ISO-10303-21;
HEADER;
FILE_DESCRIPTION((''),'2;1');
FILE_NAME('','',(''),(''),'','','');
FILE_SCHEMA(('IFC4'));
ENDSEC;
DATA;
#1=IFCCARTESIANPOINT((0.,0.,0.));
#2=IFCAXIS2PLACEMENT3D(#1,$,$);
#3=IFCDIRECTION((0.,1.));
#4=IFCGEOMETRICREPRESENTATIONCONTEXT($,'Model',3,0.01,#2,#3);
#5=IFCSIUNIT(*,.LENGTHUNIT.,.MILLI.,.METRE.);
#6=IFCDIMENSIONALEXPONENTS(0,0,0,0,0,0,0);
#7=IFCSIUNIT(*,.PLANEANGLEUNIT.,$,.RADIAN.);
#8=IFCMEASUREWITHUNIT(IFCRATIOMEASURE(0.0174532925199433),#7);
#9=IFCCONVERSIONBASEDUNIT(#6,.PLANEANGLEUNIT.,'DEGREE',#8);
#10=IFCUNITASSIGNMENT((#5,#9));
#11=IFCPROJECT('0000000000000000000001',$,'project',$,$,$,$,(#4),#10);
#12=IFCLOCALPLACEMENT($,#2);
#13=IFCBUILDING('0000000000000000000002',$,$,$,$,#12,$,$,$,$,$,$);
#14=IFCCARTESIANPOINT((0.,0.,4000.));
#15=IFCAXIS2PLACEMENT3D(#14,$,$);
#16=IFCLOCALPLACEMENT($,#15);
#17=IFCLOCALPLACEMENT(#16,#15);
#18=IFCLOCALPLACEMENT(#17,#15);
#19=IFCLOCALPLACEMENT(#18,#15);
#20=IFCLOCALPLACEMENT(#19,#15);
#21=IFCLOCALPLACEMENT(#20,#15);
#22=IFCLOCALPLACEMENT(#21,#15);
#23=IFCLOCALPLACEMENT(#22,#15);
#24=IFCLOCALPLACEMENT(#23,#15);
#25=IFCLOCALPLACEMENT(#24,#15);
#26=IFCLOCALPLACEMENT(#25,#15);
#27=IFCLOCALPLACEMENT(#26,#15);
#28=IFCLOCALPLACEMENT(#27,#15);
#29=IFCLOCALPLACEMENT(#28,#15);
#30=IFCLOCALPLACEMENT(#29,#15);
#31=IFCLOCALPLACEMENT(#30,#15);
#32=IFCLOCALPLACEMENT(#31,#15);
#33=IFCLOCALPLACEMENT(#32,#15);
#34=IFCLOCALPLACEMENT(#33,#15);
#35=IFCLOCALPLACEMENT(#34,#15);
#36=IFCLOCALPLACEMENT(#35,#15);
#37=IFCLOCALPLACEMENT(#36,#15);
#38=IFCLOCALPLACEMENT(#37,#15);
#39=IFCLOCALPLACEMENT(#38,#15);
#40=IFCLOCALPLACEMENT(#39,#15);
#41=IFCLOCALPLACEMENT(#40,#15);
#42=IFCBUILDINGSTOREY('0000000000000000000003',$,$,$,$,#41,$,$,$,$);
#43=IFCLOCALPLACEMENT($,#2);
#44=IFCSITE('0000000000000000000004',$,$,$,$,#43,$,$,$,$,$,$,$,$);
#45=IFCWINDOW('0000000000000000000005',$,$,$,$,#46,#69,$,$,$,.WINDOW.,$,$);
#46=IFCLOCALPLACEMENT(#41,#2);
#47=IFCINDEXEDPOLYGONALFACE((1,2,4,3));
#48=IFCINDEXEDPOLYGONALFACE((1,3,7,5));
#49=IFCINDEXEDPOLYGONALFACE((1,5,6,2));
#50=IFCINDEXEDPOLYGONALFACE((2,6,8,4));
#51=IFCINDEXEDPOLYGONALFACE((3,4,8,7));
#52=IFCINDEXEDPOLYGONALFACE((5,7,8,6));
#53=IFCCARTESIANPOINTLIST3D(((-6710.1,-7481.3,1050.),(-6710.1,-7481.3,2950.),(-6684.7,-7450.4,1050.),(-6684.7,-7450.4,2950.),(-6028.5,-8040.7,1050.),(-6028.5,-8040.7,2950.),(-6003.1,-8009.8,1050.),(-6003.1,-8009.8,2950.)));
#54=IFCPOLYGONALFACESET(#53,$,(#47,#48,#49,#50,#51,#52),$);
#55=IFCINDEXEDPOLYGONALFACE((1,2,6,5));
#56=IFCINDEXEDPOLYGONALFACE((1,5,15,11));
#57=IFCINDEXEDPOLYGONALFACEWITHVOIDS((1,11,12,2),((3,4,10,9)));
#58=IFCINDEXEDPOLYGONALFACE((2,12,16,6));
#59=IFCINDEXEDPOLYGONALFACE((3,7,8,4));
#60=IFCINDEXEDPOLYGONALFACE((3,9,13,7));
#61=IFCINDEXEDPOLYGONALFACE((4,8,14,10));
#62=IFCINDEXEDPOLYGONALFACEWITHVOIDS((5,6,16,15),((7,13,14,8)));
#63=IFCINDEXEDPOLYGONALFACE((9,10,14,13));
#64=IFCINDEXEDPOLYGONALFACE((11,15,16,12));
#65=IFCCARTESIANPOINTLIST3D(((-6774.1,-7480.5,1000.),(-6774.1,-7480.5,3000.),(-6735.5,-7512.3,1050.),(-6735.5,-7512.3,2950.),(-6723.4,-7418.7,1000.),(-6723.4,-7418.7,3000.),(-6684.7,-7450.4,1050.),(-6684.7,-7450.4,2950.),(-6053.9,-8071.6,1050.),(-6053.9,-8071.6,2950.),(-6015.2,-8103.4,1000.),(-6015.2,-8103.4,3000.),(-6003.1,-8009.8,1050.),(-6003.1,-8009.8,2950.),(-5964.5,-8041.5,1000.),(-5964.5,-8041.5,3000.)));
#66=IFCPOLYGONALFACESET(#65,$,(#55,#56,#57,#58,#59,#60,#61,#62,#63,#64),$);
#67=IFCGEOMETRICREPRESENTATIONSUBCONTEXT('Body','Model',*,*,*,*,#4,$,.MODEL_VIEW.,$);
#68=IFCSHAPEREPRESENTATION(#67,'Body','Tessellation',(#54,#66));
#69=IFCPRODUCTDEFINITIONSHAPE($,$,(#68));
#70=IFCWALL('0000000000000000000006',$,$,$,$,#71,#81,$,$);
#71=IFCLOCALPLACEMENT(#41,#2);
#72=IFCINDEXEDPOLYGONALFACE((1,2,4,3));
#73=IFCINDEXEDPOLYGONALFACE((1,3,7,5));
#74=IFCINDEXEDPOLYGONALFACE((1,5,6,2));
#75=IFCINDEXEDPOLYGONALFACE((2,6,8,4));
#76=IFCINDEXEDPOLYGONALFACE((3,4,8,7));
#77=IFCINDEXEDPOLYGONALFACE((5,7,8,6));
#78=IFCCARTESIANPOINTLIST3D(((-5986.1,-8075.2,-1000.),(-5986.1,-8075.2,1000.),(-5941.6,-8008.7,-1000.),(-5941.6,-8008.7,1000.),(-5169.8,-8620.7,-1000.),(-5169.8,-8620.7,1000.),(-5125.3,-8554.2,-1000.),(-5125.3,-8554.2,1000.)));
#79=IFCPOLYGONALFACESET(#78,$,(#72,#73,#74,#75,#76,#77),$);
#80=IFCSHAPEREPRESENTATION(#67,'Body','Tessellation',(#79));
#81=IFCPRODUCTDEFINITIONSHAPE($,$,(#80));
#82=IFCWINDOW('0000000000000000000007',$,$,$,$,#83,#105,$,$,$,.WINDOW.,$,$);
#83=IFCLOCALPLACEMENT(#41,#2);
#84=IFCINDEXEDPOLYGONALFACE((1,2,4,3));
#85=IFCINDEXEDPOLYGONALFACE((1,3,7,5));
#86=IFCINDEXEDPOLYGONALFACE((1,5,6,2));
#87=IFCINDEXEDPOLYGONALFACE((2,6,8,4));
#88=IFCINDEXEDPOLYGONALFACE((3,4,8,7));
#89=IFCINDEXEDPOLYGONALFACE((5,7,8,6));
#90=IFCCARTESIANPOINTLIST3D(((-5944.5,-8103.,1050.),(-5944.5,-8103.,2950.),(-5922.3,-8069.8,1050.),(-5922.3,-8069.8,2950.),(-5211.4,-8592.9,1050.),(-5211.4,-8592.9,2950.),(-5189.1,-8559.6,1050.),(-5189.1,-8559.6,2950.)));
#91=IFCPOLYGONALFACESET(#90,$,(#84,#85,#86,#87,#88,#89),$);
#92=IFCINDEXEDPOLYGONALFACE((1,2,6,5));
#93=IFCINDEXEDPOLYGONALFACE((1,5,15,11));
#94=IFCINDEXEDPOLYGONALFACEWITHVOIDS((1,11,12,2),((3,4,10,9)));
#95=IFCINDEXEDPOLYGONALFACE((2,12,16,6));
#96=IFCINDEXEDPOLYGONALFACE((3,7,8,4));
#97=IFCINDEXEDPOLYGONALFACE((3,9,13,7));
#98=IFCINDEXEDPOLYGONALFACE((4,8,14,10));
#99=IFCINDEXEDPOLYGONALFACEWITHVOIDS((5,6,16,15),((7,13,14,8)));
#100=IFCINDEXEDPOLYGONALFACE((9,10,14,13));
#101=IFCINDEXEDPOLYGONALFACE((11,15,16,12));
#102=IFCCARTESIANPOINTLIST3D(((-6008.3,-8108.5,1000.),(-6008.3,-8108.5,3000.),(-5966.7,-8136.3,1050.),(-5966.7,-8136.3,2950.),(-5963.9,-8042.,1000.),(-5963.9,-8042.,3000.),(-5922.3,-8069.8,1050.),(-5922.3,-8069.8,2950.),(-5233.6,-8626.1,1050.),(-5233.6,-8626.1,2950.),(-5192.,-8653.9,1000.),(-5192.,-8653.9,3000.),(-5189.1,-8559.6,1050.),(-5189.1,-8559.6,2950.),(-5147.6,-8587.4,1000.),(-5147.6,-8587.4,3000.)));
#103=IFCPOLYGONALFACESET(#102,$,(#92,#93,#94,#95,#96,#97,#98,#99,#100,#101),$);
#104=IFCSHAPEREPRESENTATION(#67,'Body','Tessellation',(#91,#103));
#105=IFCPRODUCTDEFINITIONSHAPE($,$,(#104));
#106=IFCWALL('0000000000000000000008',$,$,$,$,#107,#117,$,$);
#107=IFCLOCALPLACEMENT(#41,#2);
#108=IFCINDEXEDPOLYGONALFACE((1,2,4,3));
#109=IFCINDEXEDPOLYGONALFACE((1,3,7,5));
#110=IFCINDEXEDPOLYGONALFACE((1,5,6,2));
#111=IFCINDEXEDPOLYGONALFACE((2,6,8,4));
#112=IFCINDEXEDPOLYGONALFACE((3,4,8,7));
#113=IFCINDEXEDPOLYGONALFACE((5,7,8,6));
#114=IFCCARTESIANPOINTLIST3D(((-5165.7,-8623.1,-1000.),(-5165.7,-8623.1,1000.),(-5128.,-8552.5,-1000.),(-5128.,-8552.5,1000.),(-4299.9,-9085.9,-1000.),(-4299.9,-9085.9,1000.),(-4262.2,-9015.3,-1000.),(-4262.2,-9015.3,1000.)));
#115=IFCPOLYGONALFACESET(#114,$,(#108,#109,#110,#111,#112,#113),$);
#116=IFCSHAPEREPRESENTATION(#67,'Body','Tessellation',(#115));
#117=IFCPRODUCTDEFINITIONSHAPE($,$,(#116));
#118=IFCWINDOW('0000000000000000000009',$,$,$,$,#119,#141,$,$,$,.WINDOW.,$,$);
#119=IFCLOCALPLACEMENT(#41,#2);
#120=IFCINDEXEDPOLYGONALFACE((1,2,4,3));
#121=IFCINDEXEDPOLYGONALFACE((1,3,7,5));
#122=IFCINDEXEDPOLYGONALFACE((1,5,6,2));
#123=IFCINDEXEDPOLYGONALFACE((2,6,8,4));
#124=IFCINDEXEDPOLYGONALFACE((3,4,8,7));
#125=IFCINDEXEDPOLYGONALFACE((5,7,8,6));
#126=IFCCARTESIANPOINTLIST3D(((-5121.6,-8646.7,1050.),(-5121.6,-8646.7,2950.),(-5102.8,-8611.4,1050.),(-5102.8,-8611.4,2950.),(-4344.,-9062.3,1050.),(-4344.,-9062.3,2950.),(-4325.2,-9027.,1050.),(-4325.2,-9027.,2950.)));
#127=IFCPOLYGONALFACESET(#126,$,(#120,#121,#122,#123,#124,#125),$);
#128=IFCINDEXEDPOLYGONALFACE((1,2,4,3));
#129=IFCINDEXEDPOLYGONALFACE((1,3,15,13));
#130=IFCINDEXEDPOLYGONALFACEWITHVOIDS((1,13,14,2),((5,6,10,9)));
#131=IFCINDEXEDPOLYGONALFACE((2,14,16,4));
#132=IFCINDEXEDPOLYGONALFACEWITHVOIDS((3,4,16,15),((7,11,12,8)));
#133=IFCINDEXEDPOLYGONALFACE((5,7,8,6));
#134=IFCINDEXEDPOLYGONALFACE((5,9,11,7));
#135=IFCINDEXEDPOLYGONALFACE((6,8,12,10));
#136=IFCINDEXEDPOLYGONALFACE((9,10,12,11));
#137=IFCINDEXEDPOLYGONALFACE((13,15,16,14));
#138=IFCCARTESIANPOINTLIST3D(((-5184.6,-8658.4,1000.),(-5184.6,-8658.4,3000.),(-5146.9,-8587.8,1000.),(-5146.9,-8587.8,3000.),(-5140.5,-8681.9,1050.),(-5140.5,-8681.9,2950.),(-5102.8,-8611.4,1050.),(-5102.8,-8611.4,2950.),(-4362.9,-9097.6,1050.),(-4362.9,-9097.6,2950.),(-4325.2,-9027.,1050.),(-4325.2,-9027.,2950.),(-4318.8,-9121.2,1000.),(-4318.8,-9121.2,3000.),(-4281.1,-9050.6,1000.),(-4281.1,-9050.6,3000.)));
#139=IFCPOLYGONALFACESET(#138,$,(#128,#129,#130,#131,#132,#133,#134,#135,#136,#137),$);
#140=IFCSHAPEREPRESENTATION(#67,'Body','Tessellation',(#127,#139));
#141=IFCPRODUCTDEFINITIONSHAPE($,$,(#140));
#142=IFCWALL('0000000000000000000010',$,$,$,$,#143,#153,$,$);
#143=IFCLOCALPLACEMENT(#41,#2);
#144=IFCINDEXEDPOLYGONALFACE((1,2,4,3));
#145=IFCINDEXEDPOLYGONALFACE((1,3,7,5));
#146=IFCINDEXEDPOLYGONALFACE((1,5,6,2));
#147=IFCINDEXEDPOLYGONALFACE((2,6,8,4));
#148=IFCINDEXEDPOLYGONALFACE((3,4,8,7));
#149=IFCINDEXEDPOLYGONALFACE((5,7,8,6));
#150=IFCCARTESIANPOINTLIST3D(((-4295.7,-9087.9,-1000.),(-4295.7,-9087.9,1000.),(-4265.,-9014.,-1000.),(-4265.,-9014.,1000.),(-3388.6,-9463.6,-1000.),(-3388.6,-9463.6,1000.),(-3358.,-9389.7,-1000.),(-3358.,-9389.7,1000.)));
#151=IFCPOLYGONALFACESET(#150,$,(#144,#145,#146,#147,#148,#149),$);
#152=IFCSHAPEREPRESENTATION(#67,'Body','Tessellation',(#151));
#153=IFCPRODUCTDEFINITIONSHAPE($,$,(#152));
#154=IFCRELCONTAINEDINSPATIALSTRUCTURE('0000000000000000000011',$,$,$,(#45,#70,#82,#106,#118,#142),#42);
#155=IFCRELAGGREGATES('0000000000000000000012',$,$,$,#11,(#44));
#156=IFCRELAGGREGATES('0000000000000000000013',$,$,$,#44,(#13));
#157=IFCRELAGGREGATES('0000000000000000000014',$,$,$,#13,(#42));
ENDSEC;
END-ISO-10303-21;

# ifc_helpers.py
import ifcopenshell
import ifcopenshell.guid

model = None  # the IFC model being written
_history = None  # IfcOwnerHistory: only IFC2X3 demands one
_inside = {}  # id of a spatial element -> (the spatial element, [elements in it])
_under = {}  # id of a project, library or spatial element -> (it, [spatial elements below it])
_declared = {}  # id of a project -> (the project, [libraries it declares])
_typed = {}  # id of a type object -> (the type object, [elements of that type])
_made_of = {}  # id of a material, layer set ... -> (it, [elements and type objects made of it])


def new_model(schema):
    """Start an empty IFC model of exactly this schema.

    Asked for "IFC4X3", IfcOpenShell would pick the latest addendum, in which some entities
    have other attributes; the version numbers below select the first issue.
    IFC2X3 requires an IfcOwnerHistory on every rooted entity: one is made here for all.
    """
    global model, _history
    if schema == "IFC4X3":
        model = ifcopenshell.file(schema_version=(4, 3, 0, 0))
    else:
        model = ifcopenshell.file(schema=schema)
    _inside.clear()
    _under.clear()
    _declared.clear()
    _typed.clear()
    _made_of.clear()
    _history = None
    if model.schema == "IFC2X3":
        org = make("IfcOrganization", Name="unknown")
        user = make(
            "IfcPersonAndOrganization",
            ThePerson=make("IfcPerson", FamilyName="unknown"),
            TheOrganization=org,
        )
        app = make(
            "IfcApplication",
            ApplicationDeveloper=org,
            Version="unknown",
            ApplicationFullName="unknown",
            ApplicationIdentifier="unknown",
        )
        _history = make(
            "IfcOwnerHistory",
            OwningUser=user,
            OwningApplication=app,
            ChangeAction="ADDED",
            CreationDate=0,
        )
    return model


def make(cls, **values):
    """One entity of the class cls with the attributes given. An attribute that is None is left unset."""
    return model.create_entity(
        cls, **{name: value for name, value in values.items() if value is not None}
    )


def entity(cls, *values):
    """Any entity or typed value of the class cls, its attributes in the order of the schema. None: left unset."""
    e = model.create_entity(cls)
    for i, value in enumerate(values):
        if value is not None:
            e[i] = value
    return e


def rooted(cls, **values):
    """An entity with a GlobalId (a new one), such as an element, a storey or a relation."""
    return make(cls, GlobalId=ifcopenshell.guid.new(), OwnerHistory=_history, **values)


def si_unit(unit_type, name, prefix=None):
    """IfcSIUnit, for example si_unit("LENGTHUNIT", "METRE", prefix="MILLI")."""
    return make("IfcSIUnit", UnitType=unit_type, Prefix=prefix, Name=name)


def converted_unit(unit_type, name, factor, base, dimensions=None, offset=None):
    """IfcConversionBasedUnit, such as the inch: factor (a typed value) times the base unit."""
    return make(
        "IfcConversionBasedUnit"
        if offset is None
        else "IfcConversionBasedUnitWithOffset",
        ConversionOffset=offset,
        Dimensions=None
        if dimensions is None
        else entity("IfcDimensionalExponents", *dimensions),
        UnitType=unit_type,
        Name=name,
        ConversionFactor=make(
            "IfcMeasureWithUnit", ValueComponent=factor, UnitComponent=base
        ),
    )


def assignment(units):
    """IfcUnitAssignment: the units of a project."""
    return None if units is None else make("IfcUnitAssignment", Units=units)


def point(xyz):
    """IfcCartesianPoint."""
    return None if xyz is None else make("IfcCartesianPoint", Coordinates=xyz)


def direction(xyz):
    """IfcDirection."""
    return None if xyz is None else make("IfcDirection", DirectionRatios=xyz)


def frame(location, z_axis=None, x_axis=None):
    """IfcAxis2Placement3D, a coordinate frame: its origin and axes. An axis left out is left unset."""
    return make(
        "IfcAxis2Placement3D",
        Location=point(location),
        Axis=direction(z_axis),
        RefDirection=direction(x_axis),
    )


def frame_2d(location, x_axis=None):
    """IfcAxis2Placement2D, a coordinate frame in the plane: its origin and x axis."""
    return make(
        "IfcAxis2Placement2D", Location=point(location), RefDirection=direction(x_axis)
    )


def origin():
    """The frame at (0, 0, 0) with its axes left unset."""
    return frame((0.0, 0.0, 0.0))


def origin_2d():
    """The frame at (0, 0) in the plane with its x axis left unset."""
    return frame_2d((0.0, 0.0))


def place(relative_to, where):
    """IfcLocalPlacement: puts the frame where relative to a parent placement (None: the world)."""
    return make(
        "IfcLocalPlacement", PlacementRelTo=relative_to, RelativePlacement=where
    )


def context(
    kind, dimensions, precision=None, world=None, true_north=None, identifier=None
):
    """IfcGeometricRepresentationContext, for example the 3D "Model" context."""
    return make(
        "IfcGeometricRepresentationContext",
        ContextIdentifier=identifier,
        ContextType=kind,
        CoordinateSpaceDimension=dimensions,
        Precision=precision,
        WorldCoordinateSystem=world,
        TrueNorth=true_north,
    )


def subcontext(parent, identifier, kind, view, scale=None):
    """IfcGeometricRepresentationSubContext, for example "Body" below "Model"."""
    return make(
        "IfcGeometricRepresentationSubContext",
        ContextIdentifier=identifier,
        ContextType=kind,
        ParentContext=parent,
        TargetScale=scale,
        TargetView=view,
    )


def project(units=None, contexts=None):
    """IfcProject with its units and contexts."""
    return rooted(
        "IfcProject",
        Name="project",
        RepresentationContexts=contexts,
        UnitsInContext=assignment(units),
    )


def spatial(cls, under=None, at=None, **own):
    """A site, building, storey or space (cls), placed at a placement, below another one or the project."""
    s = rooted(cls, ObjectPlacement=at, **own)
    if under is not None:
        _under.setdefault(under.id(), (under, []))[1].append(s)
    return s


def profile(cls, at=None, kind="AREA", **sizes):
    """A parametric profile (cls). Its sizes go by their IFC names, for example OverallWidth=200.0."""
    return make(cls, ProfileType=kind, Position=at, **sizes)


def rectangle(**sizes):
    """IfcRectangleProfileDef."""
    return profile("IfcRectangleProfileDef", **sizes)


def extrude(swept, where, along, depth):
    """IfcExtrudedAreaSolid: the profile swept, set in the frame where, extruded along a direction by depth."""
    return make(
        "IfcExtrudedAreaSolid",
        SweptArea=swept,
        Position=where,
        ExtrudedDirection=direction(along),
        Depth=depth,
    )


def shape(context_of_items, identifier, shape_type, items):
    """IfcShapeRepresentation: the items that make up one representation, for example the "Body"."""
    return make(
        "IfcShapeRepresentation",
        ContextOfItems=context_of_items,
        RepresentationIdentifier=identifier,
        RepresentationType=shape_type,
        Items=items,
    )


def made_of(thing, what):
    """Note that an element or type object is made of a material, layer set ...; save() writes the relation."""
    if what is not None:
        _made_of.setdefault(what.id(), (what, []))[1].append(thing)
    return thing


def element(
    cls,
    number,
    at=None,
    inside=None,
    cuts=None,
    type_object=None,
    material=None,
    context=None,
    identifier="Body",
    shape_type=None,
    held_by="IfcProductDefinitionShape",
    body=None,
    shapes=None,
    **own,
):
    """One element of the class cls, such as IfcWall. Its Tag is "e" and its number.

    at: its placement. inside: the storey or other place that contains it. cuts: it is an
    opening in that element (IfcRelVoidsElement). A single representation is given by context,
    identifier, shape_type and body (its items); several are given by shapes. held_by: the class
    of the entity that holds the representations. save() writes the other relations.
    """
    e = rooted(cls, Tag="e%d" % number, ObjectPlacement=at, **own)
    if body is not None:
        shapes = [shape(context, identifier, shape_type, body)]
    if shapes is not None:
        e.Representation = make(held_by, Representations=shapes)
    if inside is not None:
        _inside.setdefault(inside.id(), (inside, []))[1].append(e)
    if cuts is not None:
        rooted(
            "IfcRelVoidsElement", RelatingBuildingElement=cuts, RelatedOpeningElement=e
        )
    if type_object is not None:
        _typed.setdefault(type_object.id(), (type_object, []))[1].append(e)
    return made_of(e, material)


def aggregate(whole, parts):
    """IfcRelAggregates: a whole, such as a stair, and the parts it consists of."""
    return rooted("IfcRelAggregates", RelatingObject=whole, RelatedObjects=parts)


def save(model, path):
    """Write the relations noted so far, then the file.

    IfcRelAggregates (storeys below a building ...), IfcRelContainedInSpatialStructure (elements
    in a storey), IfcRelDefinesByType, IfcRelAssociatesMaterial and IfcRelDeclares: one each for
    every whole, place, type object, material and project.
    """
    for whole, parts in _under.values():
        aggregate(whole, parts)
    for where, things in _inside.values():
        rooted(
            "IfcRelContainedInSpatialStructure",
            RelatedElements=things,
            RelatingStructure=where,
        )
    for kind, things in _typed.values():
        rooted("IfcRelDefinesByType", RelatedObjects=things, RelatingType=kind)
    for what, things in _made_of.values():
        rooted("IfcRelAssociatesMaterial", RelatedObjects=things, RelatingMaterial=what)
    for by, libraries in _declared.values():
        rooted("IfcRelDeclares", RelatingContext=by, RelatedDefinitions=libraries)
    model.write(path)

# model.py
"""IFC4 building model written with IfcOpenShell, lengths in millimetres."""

from ifc_helpers import new_model, entity, si_unit, converted_unit, direction, frame, origin, origin_2d, place, context, subcontext, project, spatial, rectangle, extrude, element, save


model = new_model("IFC4")

# Units and contexts
model_context = context("Model", 3, precision=0.01, world=origin(), true_north=direction((0.0, 1.0)))
body_context = subcontext(model_context, "Body", "Model", "MODEL_VIEW")
ifc_project = project(units=[si_unit("LENGTHUNIT", "METRE", prefix="MILLI"), converted_unit("PLANEANGLEUNIT", "DEGREE", entity("IfcRatioMeasure", 0.0174532925199433), si_unit("PLANEANGLEUNIT", "RADIAN"), dimensions=[0, 0, 0, 0, 0, 0, 0])], contexts=[model_context])

# Site, building, storey
site_placement = place(None, origin())
site = spatial("IfcSite", under=ifc_project, at=site_placement)
building_placement = place(None, origin())
building = spatial("IfcBuilding", under=site, at=building_placement)
placement_1 = place(None, frame((0.0, 0.0, 4000.0)))
placement_2 = place(placement_1, frame((0.0, 0.0, 4000.0)))
placement_3 = place(placement_2, frame((0.0, 0.0, 4000.0)))
placement_4 = place(placement_3, frame((0.0, 0.0, 4000.0)))
placement_5 = place(placement_4, frame((0.0, 0.0, 4000.0)))
placement_6 = place(placement_5, frame((0.0, 0.0, 4000.0)))
placement_7 = place(placement_6, frame((0.0, 0.0, 4000.0)))
placement_8 = place(placement_7, frame((0.0, 0.0, 4000.0)))
placement_9 = place(placement_8, frame((0.0, 0.0, 4000.0)))
placement_10 = place(placement_9, frame((0.0, 0.0, 4000.0)))
placement_11 = place(placement_10, frame((0.0, 0.0, 4000.0)))
placement_12 = place(placement_11, frame((0.0, 0.0, 4000.0)))
placement_13 = place(placement_12, frame((0.0, 0.0, 4000.0)))
placement_14 = place(placement_13, frame((0.0, 0.0, 4000.0)))
placement_15 = place(placement_14, frame((0.0, 0.0, 4000.0)))
placement_16 = place(placement_15, frame((0.0, 0.0, 4000.0)))
placement_17 = place(placement_16, frame((0.0, 0.0, 4000.0)))
placement_18 = place(placement_17, frame((0.0, 0.0, 4000.0)))
placement_19 = place(placement_18, frame((0.0, 0.0, 4000.0)))
placement_20 = place(placement_19, frame((0.0, 0.0, 4000.0)))
placement_21 = place(placement_20, frame((0.0, 0.0, 4000.0)))
placement_22 = place(placement_21, frame((0.0, 0.0, 4000.0)))
placement_23 = place(placement_22, frame((0.0, 0.0, 4000.0)))
placement_24 = place(placement_23, frame((0.0, 0.0, 4000.0)))
placement_25 = place(placement_24, frame((0.0, 0.0, 4000.0)))
storey_placement = place(placement_25, frame((0.0, 0.0, 4000.0)))
storey = spatial("IfcBuildingStorey", under=building, at=storey_placement)

# Shared definitions
cartesian_point_1 = entity("IfcCartesianPoint", [-440.9, -950.0])
shared_polyline = entity("IfcPolyline", [cartesian_point_1, entity("IfcCartesianPoint", [-440.9, 950.0]), entity("IfcCartesianPoint", [-440.9, 950.0]), entity("IfcCartesianPoint", [440.9, 950.0]), entity("IfcCartesianPoint", [440.9, 950.0]), entity("IfcCartesianPoint", [440.9, -950.0]), entity("IfcCartesianPoint", [440.9, -950.0]), entity("IfcCartesianPoint", [-440.9, -950.0]), cartesian_point_1])

# Window
window_1_placement = place(storey_placement, frame((-6343.9, -7730.1, 2000.0), z_axis=(0.0, 0.0, 1.0), x_axis=(7730.104346, -6343.93307, 0.0)))
cartesian_point_2 = entity("IfcCartesianPoint", [-490.9, -1000.0])
element("IfcWindow", 1, at=window_1_placement, inside=storey, PredefinedType="WINDOW", context=body_context, shape_type="SweptSolid", body=[
    entity("IfcExtrudedAreaSolid", entity("IfcArbitraryClosedProfileDef", "AREA", None, shared_polyline), entity("IfcAxis2Placement3D", entity("IfcCartesianPoint", [0.0, 0.0, 0.0]), entity("IfcDirection", [0.0, -1.0, 0.0]), entity("IfcDirection", [1.0, 0.0, 0.0])), entity("IfcDirection", [0.0, 0.0, 1.0]), 40.0),
    entity("IfcExtrudedAreaSolid", entity("IfcArbitraryProfileDefWithVoids", "AREA", None, entity("IfcPolyline", [cartesian_point_2, entity("IfcCartesianPoint", [-490.9, 1000.0]), entity("IfcCartesianPoint", [-490.9, 1000.0]), entity("IfcCartesianPoint", [490.9, 1000.0]), entity("IfcCartesianPoint", [490.9, 1000.0]), entity("IfcCartesianPoint", [490.9, -1000.0]), entity("IfcCartesianPoint", [490.9, -1000.0]), entity("IfcCartesianPoint", [-490.9, -1000.0]), cartesian_point_2]), [shared_polyline]), entity("IfcAxis2Placement3D", entity("IfcCartesianPoint", [0.0, 0.0, 0.0]), entity("IfcDirection", [0.0, -1.0, 0.0]), entity("IfcDirection", [1.0, 0.0, 0.0])), entity("IfcDirection", [0.0, 0.0, 1.0]), 80.0),
])

# Wall
wall_1_placement = place(storey_placement, frame((-5555.7, -8314.7, -1000.0), z_axis=(0.0, 0.0, 1.0), x_axis=(8314.694856, -5555.704226, 0.0)))
element("IfcWall", 2, at=wall_1_placement, inside=storey, context=body_context, shape_type="SweptSolid", body=[
    extrude(rectangle(XDim=981.7, YDim=80.0, at=origin_2d()), origin(), (0.0, 0.0, 1.0), 2000.0),
])

# Window
window_2_placement = place(storey_placement, frame((-5555.7, -8314.7, 2000.0), z_axis=(0.0, 0.0, 1.0), x_axis=(8314.694856, -5555.704226, 0.0)))
cartesian_point_3 = entity("IfcCartesianPoint", [-490.9, -1000.0])
element("IfcWindow", 3, at=window_2_placement, inside=storey, PredefinedType="WINDOW", context=body_context, shape_type="SweptSolid", body=[
    entity("IfcExtrudedAreaSolid", entity("IfcArbitraryClosedProfileDef", "AREA", None, shared_polyline), entity("IfcAxis2Placement3D", entity("IfcCartesianPoint", [0.0, 0.0, 0.0]), entity("IfcDirection", [0.0, -1.0, 0.0]), entity("IfcDirection", [1.0, 0.0, 0.0])), entity("IfcDirection", [0.0, 0.0, 1.0]), 40.0),
    entity("IfcExtrudedAreaSolid", entity("IfcArbitraryProfileDefWithVoids", "AREA", None, entity("IfcPolyline", [cartesian_point_3, entity("IfcCartesianPoint", [-490.9, 1000.0]), entity("IfcCartesianPoint", [-490.9, 1000.0]), entity("IfcCartesianPoint", [490.9, 1000.0]), entity("IfcCartesianPoint", [490.9, 1000.0]), entity("IfcCartesianPoint", [490.9, -1000.0]), entity("IfcCartesianPoint", [490.9, -1000.0]), entity("IfcCartesianPoint", [-490.9, -1000.0]), cartesian_point_3]), [shared_polyline]), entity("IfcAxis2Placement3D", entity("IfcCartesianPoint", [0.0, 0.0, 0.0]), entity("IfcDirection", [0.0, -1.0, 0.0]), entity("IfcDirection", [1.0, 0.0, 0.0])), entity("IfcDirection", [0.0, 0.0, 1.0]), 80.0),
])

# Wall
wall_2_placement = place(storey_placement, frame((-4714.0, -8819.2, -1000.0), z_axis=(0.0, 0.0, 1.0), x_axis=(8819.212881, -4713.966924, 0.0)))
element("IfcWall", 4, at=wall_2_placement, inside=storey, context=body_context, shape_type="SweptSolid", body=[
    extrude(rectangle(XDim=981.7, YDim=80.0, at=origin_2d()), origin(), (0.0, 0.0, 1.0), 2000.0),
])

# Window
window_3_placement = place(storey_placement, frame((-4714.0, -8819.2, 2000.0), z_axis=(0.0, 0.0, 1.0), x_axis=(8819.212881, -4713.966924, 0.0)))
cartesian_point_4 = entity("IfcCartesianPoint", [-490.9, -1000.0])
element("IfcWindow", 5, at=window_3_placement, inside=storey, PredefinedType="WINDOW", context=body_context, shape_type="SweptSolid", body=[
    entity("IfcExtrudedAreaSolid", entity("IfcArbitraryClosedProfileDef", "AREA", None, shared_polyline), entity("IfcAxis2Placement3D", entity("IfcCartesianPoint", [0.0, 0.0, 0.0]), entity("IfcDirection", [0.0, -1.0, 0.0]), entity("IfcDirection", [1.0, 0.0, 0.0])), entity("IfcDirection", [0.0, 0.0, 1.0]), 40.0),
    entity("IfcExtrudedAreaSolid", entity("IfcArbitraryProfileDefWithVoids", "AREA", None, entity("IfcPolyline", [cartesian_point_4, entity("IfcCartesianPoint", [-490.9, 1000.0]), entity("IfcCartesianPoint", [-490.9, 1000.0]), entity("IfcCartesianPoint", [490.9, 1000.0]), entity("IfcCartesianPoint", [490.9, 1000.0]), entity("IfcCartesianPoint", [490.9, -1000.0]), entity("IfcCartesianPoint", [490.9, -1000.0]), entity("IfcCartesianPoint", [-490.9, -1000.0]), cartesian_point_4]), [shared_polyline]), entity("IfcAxis2Placement3D", entity("IfcCartesianPoint", [0.0, 0.0, 0.0]), entity("IfcDirection", [0.0, -1.0, 0.0]), entity("IfcDirection", [1.0, 0.0, 0.0])), entity("IfcDirection", [0.0, 0.0, 1.0]), 80.0),
])

# Wall
wall_3_placement = place(storey_placement, frame((-3826.8, -9238.8, -1000.0), z_axis=(0.0, 0.0, 1.0), x_axis=(9238.794759, -3826.835691, 0.0)))
element("IfcWall", 6, at=wall_3_placement, inside=storey, context=body_context, shape_type="SweptSolid", body=[
    extrude(rectangle(XDim=981.7, YDim=80.0, at=origin_2d()), origin(), (0.0, 0.0, 1.0), 2000.0),
])

save(model, "model.ifc")
